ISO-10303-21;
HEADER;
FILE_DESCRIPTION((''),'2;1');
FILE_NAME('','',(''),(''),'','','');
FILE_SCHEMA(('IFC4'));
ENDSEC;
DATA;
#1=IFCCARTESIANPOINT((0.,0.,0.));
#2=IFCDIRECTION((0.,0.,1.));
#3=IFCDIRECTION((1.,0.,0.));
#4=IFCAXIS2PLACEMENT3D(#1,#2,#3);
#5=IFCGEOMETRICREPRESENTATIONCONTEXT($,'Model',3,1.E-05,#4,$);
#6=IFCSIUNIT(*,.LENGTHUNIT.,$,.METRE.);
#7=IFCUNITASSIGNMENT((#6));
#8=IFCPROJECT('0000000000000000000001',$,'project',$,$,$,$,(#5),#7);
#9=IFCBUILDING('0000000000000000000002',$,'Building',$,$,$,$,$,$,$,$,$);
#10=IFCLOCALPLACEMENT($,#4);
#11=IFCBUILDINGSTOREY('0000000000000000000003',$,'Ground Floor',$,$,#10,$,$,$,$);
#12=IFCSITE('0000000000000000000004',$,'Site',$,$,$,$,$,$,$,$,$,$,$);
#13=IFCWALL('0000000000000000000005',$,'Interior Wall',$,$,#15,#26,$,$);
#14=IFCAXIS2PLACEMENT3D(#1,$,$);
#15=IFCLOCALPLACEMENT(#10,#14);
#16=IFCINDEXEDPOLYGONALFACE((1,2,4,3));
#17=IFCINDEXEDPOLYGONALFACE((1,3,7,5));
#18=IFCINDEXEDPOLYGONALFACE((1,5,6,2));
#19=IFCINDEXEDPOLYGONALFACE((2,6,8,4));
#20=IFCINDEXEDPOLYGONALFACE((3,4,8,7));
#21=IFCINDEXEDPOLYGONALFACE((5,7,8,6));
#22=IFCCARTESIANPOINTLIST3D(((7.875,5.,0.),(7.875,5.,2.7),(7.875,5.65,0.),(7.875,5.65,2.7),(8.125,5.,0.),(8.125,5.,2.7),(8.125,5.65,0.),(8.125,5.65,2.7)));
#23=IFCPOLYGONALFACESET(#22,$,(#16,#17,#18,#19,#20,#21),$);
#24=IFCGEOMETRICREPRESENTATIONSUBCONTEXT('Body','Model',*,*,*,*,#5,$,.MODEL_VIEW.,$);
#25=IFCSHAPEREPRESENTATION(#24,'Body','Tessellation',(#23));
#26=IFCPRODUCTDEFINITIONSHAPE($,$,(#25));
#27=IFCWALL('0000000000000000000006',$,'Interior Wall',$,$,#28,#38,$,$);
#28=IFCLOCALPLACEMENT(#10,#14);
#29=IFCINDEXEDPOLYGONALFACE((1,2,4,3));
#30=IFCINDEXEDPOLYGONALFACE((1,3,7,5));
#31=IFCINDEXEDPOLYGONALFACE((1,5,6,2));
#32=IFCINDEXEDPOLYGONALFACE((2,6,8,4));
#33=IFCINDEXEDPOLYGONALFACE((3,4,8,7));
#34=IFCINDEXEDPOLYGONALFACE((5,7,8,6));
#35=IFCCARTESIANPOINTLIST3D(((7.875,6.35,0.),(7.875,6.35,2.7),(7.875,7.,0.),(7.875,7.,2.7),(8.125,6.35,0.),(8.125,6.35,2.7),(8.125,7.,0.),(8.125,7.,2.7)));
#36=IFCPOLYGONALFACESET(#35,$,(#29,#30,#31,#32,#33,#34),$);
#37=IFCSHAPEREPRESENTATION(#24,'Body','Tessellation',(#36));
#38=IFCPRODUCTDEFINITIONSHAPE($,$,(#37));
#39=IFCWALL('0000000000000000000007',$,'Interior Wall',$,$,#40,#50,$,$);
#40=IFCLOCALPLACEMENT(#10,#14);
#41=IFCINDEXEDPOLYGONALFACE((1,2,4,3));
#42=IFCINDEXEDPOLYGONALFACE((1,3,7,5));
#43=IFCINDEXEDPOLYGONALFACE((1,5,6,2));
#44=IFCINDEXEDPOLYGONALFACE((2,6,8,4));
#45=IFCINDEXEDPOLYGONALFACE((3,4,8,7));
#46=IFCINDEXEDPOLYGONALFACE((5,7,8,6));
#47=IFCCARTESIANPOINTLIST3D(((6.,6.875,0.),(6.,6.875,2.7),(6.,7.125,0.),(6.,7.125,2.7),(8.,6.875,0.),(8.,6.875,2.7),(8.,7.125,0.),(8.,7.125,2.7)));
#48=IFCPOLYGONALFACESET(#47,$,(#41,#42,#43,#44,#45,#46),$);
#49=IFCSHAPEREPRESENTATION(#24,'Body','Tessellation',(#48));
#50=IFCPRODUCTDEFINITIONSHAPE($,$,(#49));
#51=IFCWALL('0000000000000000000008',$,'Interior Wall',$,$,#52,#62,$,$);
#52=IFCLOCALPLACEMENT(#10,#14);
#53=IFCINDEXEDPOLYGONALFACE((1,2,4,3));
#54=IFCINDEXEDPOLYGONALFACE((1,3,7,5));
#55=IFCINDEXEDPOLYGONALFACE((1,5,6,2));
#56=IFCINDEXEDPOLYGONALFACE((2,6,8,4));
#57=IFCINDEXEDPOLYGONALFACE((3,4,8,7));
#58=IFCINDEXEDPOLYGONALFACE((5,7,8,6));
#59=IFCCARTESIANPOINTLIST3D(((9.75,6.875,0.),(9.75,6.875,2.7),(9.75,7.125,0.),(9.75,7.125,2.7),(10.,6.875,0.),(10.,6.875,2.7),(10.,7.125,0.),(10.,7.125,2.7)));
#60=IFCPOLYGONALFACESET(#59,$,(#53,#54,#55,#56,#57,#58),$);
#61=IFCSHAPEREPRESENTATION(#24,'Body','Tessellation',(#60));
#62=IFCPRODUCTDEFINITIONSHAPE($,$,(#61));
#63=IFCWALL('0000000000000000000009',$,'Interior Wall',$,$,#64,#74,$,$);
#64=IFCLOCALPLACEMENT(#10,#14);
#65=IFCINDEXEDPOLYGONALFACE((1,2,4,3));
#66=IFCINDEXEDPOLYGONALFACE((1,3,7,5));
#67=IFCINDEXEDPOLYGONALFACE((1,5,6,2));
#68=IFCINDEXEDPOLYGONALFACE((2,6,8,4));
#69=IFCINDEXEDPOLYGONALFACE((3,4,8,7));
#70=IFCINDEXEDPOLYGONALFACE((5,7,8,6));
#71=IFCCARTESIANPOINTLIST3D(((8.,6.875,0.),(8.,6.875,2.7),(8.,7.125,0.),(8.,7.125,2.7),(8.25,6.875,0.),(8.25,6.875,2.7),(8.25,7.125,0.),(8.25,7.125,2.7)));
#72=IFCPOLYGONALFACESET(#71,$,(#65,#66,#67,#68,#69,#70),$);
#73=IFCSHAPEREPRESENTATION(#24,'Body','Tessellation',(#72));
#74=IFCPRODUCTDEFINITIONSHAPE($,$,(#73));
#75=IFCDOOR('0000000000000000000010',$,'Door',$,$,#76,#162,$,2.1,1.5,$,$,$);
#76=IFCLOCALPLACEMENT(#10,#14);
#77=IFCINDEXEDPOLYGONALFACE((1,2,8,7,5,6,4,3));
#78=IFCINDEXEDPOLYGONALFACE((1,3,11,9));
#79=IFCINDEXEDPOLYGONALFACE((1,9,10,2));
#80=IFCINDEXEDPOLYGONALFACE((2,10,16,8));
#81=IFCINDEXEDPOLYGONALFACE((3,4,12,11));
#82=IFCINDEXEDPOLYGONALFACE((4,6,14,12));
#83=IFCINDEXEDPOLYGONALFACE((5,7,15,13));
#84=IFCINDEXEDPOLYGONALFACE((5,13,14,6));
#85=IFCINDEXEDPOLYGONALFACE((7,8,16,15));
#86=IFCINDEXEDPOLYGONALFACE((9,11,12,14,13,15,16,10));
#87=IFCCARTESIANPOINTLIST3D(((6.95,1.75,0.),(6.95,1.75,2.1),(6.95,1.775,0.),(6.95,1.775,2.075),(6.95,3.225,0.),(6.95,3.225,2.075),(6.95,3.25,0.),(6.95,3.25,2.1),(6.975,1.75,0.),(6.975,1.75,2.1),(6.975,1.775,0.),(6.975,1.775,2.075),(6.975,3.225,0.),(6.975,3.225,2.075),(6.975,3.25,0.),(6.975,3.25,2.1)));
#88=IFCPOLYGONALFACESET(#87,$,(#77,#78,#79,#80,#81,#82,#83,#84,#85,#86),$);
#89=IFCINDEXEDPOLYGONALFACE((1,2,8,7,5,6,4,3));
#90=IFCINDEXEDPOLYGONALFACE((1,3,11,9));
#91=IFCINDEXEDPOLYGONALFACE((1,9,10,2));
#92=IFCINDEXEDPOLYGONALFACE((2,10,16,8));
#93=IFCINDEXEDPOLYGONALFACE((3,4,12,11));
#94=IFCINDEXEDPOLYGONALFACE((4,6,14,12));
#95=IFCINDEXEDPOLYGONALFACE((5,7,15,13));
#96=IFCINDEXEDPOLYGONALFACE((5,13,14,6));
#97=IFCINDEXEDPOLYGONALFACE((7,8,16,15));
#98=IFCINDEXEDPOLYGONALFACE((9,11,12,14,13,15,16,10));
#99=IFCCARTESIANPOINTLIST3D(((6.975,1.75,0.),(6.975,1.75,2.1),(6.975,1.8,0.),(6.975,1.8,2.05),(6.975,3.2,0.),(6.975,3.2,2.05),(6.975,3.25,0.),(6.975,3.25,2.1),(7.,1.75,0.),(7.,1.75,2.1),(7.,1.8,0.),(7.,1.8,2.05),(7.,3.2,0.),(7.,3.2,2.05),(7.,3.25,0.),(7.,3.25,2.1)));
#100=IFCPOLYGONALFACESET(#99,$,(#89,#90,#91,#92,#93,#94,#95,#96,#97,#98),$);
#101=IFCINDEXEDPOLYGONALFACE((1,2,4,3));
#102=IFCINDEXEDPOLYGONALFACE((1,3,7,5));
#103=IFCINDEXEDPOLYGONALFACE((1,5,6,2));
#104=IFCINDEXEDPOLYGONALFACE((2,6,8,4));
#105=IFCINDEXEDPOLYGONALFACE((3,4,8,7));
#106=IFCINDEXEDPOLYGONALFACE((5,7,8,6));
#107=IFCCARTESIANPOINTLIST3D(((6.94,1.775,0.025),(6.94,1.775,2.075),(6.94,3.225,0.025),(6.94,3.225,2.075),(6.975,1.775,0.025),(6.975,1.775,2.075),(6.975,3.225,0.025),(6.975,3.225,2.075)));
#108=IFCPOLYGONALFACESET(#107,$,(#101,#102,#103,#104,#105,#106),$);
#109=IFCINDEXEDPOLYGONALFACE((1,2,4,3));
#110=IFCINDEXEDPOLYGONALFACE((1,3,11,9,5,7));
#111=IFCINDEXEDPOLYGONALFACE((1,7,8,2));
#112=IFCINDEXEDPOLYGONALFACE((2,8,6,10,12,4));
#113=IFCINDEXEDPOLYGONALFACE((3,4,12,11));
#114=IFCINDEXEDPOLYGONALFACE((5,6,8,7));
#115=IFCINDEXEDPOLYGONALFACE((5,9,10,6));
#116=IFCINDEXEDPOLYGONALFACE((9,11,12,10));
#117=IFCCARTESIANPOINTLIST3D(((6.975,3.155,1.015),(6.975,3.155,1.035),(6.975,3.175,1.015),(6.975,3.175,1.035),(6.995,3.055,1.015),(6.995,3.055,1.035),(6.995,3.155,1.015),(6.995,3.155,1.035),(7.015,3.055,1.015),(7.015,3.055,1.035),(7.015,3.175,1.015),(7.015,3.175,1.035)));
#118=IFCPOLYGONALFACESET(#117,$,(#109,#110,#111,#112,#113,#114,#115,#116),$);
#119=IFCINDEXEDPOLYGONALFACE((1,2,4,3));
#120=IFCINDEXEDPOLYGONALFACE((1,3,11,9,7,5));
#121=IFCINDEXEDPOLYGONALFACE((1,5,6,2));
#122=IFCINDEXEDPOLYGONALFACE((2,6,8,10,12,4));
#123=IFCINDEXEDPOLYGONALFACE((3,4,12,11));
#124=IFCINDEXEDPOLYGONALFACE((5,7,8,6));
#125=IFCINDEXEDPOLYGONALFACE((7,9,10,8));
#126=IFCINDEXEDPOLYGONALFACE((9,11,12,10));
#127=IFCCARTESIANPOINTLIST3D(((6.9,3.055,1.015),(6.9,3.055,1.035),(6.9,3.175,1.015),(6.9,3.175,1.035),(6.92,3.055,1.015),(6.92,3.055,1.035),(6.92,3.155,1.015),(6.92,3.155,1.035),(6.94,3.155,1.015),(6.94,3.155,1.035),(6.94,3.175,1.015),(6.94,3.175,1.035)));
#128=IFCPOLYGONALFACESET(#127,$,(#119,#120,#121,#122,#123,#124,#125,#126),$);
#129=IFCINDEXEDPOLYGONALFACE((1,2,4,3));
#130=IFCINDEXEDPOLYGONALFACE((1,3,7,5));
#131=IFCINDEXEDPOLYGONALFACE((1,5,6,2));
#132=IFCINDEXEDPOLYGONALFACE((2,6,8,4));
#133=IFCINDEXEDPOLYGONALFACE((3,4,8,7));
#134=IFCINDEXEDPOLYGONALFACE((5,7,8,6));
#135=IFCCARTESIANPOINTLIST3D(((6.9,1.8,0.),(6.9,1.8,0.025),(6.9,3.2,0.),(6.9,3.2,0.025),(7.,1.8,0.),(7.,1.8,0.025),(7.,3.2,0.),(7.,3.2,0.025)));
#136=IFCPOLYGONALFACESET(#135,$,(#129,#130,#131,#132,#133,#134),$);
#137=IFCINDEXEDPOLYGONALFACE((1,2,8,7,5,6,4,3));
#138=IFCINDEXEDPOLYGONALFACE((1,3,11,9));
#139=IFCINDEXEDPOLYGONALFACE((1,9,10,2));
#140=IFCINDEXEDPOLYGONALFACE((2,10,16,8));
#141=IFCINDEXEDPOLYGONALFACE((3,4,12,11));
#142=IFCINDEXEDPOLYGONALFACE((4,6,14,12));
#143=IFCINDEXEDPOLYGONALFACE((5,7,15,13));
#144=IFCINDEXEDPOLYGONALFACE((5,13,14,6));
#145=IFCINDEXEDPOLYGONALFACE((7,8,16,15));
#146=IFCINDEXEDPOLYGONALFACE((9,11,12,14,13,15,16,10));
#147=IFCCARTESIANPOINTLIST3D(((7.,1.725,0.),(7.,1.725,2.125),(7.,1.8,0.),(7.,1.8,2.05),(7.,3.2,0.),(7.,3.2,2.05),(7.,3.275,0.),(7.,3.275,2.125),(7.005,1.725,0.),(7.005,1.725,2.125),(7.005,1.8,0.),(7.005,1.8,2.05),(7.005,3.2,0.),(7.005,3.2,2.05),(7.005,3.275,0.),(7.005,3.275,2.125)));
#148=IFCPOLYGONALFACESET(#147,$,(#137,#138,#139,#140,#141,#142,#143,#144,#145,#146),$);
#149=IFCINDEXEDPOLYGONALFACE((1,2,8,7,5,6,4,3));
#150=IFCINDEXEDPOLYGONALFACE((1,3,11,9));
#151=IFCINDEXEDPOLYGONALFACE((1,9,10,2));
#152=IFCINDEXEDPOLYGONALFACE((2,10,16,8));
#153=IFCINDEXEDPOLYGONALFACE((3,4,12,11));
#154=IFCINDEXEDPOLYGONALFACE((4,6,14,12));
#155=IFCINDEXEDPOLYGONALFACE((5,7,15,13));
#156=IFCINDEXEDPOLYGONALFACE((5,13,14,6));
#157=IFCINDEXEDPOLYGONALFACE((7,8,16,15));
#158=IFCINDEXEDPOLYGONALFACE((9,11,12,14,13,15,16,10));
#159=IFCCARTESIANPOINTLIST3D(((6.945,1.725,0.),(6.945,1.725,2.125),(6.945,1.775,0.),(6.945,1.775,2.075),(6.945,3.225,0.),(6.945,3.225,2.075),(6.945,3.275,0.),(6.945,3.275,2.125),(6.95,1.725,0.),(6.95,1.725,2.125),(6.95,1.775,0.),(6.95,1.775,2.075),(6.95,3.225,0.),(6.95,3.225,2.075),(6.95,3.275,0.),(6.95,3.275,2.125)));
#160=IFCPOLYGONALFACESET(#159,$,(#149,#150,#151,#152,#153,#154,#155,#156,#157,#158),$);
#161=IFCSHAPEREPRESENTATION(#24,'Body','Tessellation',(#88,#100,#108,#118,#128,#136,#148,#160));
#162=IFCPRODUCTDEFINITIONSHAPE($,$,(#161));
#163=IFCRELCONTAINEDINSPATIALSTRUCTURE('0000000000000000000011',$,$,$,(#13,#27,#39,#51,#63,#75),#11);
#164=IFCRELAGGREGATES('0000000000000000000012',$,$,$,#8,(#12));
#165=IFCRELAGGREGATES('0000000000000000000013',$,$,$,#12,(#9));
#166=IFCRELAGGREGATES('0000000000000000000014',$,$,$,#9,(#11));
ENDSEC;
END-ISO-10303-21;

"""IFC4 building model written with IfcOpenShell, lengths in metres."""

from ifc_helpers import new_model, si_unit, frame, origin_with_axes, place, context, subcontext, project, spatial, line, indexed_curve, outline, extrude, element, save


model = new_model("IFC4")

# Units and contexts
model_context = context("Model", 3, precision=1e-05, world=origin_with_axes())
body_context = subcontext(model_context, "Body", "Model", "MODEL_VIEW")
ifc_project = project(units=[si_unit("LENGTHUNIT", "METRE")], contexts=[model_context])

# Site, building, storey
site = spatial("IfcSite", under=ifc_project, Name="Site")
building = spatial("IfcBuilding", under=site, Name="Building")
storey_placement = place(None, origin_with_axes())
storey = spatial("IfcBuildingStorey", under=building, at=storey_placement, Name="Ground Floor")

# Walls
for number, where, z_axis, x_axis, name in (
    (1, (8.0, 5.0, 0.0), (0.0, 0.0, 1.0), (0.0, 1.0, 0.0), "Interior Wall"),
    (2, (8.0, 6.35, 0.0), (0.0, 0.0, 1.0), (0.0, 1.0, 0.0), "Interior Wall"),
):
    element("IfcWall", number, at=place(storey_placement, frame(where, z_axis=z_axis, x_axis=x_axis)), inside=storey, Name=name, context=body_context, shape_type="SweptSolid", body=[
        extrude(outline(indexed_curve([(0.0, 0.0), (0.0, 0.25), (0.65, 0.25), (0.65, 0.0), (0.0, 0.0)], self_intersect=False)), frame((0.0, -0.125, 0.0), z_axis=(0.0, 0.0, 1.0), x_axis=(1.0, 0.0, 0.0)), (0.0, 0.0, 1.0), 2.7),
    ])
wall_1_placement = place(storey_placement, frame((8.0, 7.0, 0.0), z_axis=(0.0, 0.0, 1.0), x_axis=(-1.0, 0.0, 0.0)))
element("IfcWall", 3, at=wall_1_placement, inside=storey, Name="Interior Wall", context=body_context, shape_type="SweptSolid", body=[
    extrude(outline(indexed_curve([(0.0, 0.0), (0.0, 0.25), (2.0, 0.25), (2.0, 0.0), (0.0, 0.0)], self_intersect=False)), frame((0.0, -0.125, 0.0), z_axis=(0.0, 0.0, 1.0), x_axis=(1.0, 0.0, 0.0)), (0.0, 0.0, 1.0), 2.7),
])
for number, where, z_axis, x_axis, name in (
    (4, (10.0, 7.0, 0.0), (0.0, 0.0, 1.0), (-1.0, 0.0, 0.0), "Interior Wall"),
    (5, (8.25, 7.0, 0.0), (0.0, 0.0, 1.0), (-1.0, 0.0, 0.0), "Interior Wall"),
):
    element("IfcWall", number, at=place(storey_placement, frame(where, z_axis=z_axis, x_axis=x_axis)), inside=storey, Name=name, context=body_context, shape_type="SweptSolid", body=[
        extrude(outline(indexed_curve([(0.0, 0.0), (0.0, 0.25), (0.25, 0.25), (0.25, 0.0), (0.0, 0.0)], self_intersect=False)), frame((0.0, -0.125, 0.0), z_axis=(0.0, 0.0, 1.0), x_axis=(1.0, 0.0, 0.0)), (0.0, 0.0, 1.0), 2.7),
    ])

# Door
door_1_placement = place(storey_placement, frame((7.0, 1.75, 0.0), z_axis=(0.0, 0.0, 1.0), x_axis=(0.0, 1.0, 0.0)))
element("IfcDoor", 6, at=door_1_placement, inside=storey, Name="Door", OverallHeight=2.1, OverallWidth=1.5, context=body_context, shape_type="SweptSolid", body=[
    extrude(outline(indexed_curve([(0.0, 0.0), (0.0, 2.1), (1.5, 2.1), (1.5, 0.0), (1.475, 0.0), (1.475, 2.075), (0.025, 2.075), (0.025, 0.0)], segments=[line(1, 2, 3, 4, 5, 6, 7, 8, 1)])), frame((0.0, 0.025, 0.0), z_axis=(0.0, -1.0, 0.0), x_axis=(1.0, 0.0, 0.0)), (0.0, 0.0, -1.0), 0.025),
    extrude(outline(indexed_curve([(0.0, 0.0), (0.0, 2.1), (1.5, 2.1), (1.5, 0.0), (1.45, 0.0), (1.45, 2.05), (0.05, 2.05), (0.05, 0.0)], segments=[line(1, 2, 3, 4, 5, 6, 7, 8, 1)])), frame((0.0, 0.0, 0.0), z_axis=(0.0, -1.0, 0.0), x_axis=(1.0, 0.0, 0.0)), (0.0, 0.0, -1.0), 0.025),
    extrude(outline(indexed_curve([(0.0, 0.0), (1.45, 0.0), (1.45, 0.035), (0.0, 0.035)], segments=[line(1, 2, 3, 4, 1)])), frame((0.025, 0.025, 0.025), z_axis=(0.0, 0.0, 1.0), x_axis=(1.0, 0.0, 0.0)), (0.0, 0.0, 1.0), 2.05),
    extrude(outline(indexed_curve([(0.0, 0.0), (0.0, -0.04), (-0.12, -0.04), (-0.12, -0.02), (-0.02, -0.02), (-0.02, 0.0)], segments=[line(1, 2, 3, 4, 5, 6, 1)])), frame((1.425, 0.025, 1.015), z_axis=(0.0, 0.0, 1.0), x_axis=(1.0, 0.0, 0.0)), (0.0, 0.0, 1.0), 0.02),
    extrude(outline(indexed_curve([(0.0, 0.0), (0.0, 0.04), (-0.12, 0.04), (-0.12, 0.02), (-0.02, 0.02), (-0.02, 0.0)], segments=[line(1, 2, 3, 4, 5, 6, 1)])), frame((1.425, 0.06, 1.015), z_axis=(0.0, 0.0, 1.0), x_axis=(1.0, 0.0, 0.0)), (0.0, 0.0, 1.0), 0.02),
    extrude(outline(indexed_curve([(0.0, 0.0), (1.4, 0.0), (1.4, 0.1), (0.0, 0.1)], segments=[line(1, 2, 3, 4, 1)])), frame((0.05, 0.0, 0.0), z_axis=(0.0, 0.0, 1.0), x_axis=(1.0, 0.0, 0.0)), (0.0, 0.0, 1.0), 0.025),
    extrude(outline(indexed_curve([(0.0, 0.0), (0.0, 2.125), (1.55, 2.125), (1.55, 0.0), (1.475, 0.0), (1.475, 2.05), (0.075, 2.05), (0.075, 0.0)], segments=[line(1, 2, 3, 4, 5, 6, 7, 8, 1)])), frame((-0.025, -0.005, 0.0), z_axis=(0.0, -1.0, 0.0), x_axis=(1.0, 0.0, 0.0)), (0.0, 0.0, -1.0), 0.005),
    extrude(outline(indexed_curve([(0.0, 0.0), (0.0, 2.125), (1.55, 2.125), (1.55, 0.0), (1.5, 0.0), (1.5, 2.075), (0.05, 2.075), (0.05, 0.0)], segments=[line(1, 2, 3, 4, 5, 6, 7, 8, 1)])), frame((-0.025, 0.05, 0.0), z_axis=(0.0, -1.0, 0.0), x_axis=(1.0, 0.0, 0.0)), (0.0, 0.0, -1.0), 0.005),
])

save(model, "model.ifc")
